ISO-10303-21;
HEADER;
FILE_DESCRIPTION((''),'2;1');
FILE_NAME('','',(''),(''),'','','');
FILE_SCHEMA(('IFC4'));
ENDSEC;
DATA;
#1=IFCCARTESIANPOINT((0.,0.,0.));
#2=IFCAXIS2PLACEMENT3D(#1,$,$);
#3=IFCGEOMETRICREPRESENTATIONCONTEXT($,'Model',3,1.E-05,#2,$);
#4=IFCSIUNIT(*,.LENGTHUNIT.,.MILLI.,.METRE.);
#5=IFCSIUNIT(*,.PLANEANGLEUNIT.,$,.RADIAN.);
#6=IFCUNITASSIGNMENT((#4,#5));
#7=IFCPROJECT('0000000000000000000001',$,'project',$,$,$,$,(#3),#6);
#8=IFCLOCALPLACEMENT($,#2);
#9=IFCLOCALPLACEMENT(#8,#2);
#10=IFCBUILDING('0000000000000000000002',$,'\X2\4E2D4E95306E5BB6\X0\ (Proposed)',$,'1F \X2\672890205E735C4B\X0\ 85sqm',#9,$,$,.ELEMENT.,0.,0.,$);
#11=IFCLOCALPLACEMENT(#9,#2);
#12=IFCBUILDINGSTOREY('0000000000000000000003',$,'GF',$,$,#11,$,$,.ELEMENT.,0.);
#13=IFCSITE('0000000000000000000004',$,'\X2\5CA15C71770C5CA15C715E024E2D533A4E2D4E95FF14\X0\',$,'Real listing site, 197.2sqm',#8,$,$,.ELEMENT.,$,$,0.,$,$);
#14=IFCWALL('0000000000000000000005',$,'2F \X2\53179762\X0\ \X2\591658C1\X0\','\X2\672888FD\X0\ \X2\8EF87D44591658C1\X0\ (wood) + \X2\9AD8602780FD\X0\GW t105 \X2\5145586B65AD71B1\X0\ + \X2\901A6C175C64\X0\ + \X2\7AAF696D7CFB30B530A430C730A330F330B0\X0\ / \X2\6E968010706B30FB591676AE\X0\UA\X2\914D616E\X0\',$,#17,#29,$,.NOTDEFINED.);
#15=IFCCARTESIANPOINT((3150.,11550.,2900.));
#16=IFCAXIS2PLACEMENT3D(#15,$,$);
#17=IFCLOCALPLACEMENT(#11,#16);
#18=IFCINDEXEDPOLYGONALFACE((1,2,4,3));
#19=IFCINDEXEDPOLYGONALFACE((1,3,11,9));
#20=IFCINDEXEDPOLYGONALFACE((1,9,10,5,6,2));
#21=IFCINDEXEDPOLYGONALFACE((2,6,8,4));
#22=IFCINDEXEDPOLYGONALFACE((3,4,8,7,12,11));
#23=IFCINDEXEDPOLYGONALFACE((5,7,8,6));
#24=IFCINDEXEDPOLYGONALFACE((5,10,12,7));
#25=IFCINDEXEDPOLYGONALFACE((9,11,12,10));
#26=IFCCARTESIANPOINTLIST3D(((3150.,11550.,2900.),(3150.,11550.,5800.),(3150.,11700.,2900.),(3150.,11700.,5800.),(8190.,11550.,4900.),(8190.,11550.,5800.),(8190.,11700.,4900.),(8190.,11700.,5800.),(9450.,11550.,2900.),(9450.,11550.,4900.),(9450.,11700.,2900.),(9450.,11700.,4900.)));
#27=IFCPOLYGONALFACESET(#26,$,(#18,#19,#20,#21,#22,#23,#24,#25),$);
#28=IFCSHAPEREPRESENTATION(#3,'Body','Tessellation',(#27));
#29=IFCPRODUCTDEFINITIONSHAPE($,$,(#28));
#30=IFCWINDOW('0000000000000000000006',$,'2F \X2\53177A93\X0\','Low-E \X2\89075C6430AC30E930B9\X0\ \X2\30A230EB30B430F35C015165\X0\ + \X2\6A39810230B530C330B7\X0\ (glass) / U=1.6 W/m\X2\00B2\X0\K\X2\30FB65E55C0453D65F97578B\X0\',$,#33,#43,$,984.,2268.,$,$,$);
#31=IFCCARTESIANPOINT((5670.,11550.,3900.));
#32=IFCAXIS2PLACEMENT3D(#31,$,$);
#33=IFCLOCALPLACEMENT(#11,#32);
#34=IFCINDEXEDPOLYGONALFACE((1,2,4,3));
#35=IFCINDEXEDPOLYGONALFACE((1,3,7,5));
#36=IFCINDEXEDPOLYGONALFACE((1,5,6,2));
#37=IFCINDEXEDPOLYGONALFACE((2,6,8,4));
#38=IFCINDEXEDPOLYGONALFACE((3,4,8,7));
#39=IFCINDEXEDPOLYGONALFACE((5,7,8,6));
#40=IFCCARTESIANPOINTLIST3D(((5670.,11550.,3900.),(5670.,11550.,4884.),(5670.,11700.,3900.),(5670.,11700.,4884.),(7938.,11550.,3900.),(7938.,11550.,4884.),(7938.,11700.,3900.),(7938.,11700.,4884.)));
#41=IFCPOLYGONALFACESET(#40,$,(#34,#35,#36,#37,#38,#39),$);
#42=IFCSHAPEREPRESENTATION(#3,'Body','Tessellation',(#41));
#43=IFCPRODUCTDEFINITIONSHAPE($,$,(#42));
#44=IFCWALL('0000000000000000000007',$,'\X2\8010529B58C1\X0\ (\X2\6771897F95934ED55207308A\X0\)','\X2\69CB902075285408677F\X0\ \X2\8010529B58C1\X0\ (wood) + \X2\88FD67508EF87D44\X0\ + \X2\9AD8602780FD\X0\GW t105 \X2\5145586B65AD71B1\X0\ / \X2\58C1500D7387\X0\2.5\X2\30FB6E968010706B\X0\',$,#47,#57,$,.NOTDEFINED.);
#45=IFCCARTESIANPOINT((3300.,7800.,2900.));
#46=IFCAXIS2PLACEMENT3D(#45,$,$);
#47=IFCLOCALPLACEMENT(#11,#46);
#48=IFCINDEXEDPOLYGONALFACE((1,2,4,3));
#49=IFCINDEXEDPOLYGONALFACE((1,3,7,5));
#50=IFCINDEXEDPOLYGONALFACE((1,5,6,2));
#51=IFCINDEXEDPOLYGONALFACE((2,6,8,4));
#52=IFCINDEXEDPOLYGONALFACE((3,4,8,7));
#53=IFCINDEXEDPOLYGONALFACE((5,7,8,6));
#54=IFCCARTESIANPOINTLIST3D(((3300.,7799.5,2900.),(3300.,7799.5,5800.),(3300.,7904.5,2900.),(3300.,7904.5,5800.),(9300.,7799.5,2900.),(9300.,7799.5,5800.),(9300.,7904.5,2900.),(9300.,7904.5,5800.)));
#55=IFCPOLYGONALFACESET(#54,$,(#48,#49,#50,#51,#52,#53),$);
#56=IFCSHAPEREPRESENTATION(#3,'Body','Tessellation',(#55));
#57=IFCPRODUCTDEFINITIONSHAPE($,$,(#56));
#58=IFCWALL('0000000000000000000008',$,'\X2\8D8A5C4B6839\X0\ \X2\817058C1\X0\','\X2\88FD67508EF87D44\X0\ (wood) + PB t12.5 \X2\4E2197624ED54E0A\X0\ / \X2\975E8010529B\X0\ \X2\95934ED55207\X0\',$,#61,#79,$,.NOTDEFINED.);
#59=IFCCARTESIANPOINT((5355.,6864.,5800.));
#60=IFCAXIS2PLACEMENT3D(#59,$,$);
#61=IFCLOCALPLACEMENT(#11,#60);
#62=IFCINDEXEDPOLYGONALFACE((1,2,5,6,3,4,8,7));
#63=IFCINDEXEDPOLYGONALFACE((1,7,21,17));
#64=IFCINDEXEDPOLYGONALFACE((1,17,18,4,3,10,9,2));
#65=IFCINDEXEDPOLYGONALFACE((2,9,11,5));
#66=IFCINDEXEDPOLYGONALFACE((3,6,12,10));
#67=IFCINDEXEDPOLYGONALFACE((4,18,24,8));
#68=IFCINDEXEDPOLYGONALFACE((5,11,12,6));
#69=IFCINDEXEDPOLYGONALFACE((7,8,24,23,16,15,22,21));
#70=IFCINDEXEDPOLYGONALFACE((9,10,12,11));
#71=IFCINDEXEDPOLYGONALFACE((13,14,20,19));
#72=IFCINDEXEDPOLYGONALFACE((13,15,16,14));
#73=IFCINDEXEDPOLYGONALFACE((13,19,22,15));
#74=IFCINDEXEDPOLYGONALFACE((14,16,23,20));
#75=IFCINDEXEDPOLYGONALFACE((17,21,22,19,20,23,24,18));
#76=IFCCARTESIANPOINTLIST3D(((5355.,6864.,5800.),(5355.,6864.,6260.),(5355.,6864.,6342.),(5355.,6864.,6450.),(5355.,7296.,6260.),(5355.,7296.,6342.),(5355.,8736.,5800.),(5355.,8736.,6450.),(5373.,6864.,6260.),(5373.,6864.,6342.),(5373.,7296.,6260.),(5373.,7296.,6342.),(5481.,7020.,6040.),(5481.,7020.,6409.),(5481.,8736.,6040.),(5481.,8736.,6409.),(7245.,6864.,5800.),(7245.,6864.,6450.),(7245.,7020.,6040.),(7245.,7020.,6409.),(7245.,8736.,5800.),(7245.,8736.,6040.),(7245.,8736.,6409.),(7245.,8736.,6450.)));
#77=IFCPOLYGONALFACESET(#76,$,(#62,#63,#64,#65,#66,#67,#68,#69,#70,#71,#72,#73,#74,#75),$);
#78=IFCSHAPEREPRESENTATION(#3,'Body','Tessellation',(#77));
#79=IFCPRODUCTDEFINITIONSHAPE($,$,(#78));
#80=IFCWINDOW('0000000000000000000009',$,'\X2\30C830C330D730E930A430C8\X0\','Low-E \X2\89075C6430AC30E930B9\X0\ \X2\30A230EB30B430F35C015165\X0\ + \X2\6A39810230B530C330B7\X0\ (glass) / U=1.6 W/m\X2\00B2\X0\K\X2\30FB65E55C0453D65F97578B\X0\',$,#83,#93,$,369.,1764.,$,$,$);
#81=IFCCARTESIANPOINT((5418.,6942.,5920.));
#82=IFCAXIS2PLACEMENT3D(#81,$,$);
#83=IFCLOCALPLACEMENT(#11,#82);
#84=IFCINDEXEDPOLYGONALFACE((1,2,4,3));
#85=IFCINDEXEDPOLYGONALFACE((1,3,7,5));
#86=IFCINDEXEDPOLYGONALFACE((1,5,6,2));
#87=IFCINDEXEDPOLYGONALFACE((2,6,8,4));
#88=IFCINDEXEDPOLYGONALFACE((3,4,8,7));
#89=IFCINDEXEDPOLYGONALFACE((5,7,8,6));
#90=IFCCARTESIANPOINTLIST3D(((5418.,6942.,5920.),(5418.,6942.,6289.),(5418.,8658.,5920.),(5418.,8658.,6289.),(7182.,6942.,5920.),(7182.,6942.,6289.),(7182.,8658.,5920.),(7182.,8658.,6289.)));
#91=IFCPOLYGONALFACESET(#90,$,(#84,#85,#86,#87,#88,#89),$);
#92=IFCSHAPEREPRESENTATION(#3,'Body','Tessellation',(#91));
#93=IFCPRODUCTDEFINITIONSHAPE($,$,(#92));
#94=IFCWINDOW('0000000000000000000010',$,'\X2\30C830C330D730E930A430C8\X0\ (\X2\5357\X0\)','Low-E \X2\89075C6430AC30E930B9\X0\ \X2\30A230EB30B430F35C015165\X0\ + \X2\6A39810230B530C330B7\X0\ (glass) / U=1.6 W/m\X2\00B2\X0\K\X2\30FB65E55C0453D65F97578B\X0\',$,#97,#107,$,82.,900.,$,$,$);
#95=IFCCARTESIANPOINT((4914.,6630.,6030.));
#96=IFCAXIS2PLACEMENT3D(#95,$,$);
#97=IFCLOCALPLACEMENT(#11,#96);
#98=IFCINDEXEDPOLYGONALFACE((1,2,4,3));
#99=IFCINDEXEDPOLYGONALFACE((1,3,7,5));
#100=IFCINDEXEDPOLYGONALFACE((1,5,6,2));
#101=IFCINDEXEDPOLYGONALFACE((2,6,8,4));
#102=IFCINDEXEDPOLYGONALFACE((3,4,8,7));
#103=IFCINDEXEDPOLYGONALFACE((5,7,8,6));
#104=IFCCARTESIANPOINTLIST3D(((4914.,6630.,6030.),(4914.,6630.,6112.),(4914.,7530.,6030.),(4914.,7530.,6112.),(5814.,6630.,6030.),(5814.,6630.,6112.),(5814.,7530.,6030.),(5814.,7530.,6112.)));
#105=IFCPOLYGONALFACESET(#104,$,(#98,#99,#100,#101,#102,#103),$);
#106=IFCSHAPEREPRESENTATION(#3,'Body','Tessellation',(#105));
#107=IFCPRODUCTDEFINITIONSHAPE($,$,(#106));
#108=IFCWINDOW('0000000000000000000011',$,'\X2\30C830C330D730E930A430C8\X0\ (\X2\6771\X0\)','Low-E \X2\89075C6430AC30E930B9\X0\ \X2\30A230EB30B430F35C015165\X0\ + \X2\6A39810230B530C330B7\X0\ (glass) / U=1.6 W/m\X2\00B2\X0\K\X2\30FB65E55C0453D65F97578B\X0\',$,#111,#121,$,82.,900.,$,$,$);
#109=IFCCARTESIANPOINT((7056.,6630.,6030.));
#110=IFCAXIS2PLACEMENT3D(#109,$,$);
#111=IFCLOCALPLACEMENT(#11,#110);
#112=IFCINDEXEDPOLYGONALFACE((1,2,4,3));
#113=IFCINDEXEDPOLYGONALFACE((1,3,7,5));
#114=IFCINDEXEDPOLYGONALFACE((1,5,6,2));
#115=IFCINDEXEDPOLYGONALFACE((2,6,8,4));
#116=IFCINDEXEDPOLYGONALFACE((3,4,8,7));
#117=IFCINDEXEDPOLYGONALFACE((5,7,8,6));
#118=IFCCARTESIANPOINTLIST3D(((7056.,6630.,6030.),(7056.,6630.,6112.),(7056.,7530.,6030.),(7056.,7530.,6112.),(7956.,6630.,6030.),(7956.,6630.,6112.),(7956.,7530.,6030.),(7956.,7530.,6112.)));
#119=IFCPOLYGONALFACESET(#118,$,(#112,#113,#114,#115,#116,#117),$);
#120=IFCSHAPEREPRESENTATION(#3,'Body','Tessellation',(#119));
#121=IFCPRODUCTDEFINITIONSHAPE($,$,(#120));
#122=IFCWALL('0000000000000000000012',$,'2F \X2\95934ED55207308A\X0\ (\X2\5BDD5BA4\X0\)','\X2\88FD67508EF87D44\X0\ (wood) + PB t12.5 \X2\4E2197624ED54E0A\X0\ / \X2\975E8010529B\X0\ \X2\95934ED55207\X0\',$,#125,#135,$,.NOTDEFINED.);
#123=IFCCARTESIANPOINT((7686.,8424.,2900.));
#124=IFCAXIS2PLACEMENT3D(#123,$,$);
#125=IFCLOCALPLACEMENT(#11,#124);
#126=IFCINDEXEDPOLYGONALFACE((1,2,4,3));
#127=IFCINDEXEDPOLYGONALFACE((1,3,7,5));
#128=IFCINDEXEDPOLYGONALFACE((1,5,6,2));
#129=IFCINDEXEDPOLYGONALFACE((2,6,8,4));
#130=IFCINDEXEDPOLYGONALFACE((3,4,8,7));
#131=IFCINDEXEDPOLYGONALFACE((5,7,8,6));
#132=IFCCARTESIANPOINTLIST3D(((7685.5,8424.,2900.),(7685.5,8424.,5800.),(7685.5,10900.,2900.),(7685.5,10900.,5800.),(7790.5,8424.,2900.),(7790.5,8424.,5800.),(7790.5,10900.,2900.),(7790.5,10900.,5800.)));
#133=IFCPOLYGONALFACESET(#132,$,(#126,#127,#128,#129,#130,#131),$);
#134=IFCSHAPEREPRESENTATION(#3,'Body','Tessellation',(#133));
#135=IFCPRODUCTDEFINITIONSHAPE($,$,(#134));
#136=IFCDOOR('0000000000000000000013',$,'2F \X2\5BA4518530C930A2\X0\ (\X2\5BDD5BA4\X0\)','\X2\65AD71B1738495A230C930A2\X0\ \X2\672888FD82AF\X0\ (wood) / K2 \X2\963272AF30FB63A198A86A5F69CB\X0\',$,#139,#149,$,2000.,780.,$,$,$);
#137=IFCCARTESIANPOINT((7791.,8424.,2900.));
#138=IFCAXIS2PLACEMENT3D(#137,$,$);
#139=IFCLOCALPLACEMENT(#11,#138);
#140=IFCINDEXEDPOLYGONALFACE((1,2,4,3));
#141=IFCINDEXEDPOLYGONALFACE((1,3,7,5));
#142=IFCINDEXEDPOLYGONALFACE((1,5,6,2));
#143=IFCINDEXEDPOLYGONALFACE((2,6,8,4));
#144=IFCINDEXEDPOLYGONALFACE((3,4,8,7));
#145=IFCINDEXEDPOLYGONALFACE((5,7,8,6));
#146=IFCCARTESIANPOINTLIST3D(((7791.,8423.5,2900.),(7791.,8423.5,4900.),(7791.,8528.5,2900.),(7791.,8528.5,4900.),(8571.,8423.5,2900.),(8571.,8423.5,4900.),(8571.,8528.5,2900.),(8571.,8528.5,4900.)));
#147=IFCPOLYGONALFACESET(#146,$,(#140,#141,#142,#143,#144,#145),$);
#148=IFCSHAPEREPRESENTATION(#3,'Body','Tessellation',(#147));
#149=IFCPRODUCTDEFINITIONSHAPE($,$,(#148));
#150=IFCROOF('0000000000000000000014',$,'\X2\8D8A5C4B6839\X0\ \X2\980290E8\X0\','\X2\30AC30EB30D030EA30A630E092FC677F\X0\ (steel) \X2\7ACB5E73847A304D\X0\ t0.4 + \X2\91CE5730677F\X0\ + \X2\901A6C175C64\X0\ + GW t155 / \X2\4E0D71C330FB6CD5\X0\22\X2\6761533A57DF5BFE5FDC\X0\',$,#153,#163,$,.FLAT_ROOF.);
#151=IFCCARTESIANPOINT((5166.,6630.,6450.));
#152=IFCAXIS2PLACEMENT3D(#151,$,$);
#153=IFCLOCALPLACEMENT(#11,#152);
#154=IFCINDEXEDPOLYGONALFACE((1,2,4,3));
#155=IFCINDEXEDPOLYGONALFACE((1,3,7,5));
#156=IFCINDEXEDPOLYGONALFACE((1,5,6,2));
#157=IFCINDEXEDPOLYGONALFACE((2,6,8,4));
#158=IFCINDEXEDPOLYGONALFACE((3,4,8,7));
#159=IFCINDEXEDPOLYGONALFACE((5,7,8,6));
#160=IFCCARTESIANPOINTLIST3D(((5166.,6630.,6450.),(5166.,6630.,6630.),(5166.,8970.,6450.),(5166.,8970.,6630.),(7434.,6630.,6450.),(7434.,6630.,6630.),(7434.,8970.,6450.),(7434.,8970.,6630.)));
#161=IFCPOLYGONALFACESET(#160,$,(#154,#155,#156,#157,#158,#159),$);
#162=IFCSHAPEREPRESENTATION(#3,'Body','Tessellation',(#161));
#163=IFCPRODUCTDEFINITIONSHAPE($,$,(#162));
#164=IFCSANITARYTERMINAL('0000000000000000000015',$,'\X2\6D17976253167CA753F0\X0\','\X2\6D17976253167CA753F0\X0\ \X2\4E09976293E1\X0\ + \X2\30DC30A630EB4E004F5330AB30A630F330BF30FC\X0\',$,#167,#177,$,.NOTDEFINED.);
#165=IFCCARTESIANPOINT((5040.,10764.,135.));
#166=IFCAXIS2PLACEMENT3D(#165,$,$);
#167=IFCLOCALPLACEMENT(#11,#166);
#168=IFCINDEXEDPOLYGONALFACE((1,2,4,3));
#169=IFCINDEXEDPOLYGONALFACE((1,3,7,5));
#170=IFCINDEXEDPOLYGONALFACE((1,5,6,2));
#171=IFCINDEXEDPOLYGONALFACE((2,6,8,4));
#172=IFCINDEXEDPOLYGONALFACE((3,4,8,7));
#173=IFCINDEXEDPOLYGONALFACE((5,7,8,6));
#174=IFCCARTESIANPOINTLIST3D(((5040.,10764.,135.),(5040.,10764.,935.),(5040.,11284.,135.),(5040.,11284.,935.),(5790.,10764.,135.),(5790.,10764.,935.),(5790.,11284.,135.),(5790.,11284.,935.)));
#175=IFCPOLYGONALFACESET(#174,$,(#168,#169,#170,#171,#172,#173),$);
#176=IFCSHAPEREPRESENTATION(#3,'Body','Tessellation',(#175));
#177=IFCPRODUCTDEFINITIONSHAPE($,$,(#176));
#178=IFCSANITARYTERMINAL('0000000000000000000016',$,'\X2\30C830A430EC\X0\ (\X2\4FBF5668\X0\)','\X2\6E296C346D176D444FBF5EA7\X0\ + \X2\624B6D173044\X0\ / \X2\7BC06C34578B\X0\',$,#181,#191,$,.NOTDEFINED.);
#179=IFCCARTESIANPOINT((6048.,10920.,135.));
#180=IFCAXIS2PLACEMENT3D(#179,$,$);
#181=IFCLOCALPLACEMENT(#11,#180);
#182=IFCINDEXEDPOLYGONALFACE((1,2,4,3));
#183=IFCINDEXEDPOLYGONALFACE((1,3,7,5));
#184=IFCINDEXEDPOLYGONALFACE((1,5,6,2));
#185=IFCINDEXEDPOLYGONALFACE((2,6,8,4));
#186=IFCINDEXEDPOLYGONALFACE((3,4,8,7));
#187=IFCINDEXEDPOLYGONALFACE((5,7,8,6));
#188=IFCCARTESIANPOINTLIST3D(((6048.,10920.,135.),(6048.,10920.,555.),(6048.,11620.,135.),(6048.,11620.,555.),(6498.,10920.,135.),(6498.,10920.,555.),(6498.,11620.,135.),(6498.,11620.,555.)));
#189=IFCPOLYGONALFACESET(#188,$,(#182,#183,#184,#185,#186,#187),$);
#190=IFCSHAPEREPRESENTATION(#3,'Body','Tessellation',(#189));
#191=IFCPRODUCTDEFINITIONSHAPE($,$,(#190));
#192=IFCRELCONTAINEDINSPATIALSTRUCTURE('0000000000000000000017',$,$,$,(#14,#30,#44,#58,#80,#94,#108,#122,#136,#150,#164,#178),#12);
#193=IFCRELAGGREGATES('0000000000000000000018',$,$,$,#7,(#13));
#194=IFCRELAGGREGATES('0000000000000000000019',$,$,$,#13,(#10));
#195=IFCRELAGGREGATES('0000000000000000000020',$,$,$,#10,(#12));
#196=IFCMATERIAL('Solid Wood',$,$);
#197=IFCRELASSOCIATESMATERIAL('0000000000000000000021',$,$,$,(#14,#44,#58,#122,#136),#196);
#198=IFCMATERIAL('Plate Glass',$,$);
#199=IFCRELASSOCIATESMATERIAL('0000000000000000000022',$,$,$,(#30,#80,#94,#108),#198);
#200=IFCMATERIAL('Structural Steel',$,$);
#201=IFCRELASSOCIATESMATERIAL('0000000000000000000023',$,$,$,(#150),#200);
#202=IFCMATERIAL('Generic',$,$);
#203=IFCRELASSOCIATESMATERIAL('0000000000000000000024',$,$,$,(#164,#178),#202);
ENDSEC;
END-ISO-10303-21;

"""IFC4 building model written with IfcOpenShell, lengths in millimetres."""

from ifc_helpers import new_model, si_unit, frame, frame_2d, origin, place, context, project, spatial, rectangle, extrude, material, element, fill, save


model = new_model("IFC4")

# Units and contexts
model_context = context("Model", 3, precision=1e-05, world=origin())
ifc_project = project(units=[si_unit("LENGTHUNIT", "METRE", prefix="MILLI"), si_unit("PLANEANGLEUNIT", "RADIAN")], contexts=[model_context])

# Site, building, storey
site_placement = place(None, origin())
site = spatial("IfcSite", under=ifc_project, at=site_placement, Name="岡山県岡山市中区中井４", ObjectType="Real listing site, 197.2sqm", CompositionType="ELEMENT", RefElevation=0.0)
building_placement = place(site_placement, origin())
building = spatial("IfcBuilding", under=site, at=building_placement, Name="中井の家 (Proposed)", ObjectType="1F 木造平屋 85sqm", CompositionType="ELEMENT", ElevationOfRefHeight=0.0, ElevationOfTerrain=0.0)
storey_placement = place(building_placement, origin())
storey = spatial("IfcBuildingStorey", under=building, at=storey_placement, Name="GF", CompositionType="ELEMENT", Elevation=0.0)

# Wall, opening, window
ifc_material_1 = material(Name="Solid Wood")
wall_1_placement = place(storey_placement, frame((3150.0, 11550.0, 2900.0)))
wall_1 = element("IfcWall", 1, at=wall_1_placement, inside=storey, material=ifc_material_1, Name="2F 北面 外壁", Description="木製 軸組外壁 (wood) + 高性能GW t105 充填断熱 + 通気層 + 窯業系サイディング / 準耐火・外皮UA配慮", PredefinedType="NOTDEFINED", context=model_context, shape_type="SweptSolid", body=[
    extrude(rectangle(XDim=6300.0, YDim=150.0, at=frame_2d((3150.0, 75.0))), frame((3150.0, 11550.0, 2900.0)), (0.0, 0.0, 1.0), 2900.0),
])
opening_1_placement = place(storey_placement, frame((5670.0, 11550.0, 3900.0)))
opening_1 = element("IfcOpeningElement", 2, at=opening_1_placement, cuts=wall_1, PredefinedType="NOTDEFINED", context=model_context, shape_type="SweptSolid", body=[
    extrude(rectangle(XDim=2268.0, YDim=150.0, at=frame_2d((1134.0, 75.0))), frame((5670.0, 11550.0, 3900.0)), (0.0, 0.0, 1.0), 984.0),
])
ifc_material_2 = material(Name="Plate Glass")
window_1_placement = place(storey_placement, frame((5670.0, 11550.0, 3900.0)))
window_1 = element("IfcWindow", 3, at=window_1_placement, inside=storey, material=ifc_material_2, Name="2F 北窓", Description="Low-E 複層ガラス アルゴン封入 + 樹脂サッシ (glass) / U=1.6 W/m²K・日射取得型", OverallHeight=984.0, OverallWidth=2268.0, context=model_context, shape_type="SweptSolid", body=[
    extrude(rectangle(XDim=2268.0, YDim=150.0, at=frame_2d((1134.0, 75.0))), frame((5670.0, 11550.0, 3900.0)), (0.0, 0.0, 1.0), 984.0),
])
fill(opening_1, window_1)

# Wall
wall_2_placement = place(storey_placement, frame((3300.0, 7800.0, 2900.0)))
element("IfcWall", 4, at=wall_2_placement, inside=storey, material=ifc_material_1, Name="耐力壁 (東西間仕切り)", Description="構造用合板 耐力壁 (wood) + 製材軸組 + 高性能GW t105 充填断熱 / 壁倍率2.5・準耐火", PredefinedType="NOTDEFINED", context=model_context, shape_type="SweptSolid", body=[
    extrude(rectangle(XDim=6000.0, YDim=105.0, at=frame_2d((3000.0, 52.0))), frame((3300.0, 7800.0, 2900.0)), (0.0, 0.0, 1.0), 2900.0),
])

# Wall, openings, windows
wall_3_placement = place(storey_placement, frame((5355.0, 6864.0, 5800.0)))
wall_3 = element("IfcWall", 5, at=wall_3_placement, inside=storey, material=ifc_material_1, Name="越屋根 腰壁", Description="製材軸組 (wood) + PB t12.5 両面仕上 / 非耐力 間仕切", PredefinedType="NOTDEFINED", context=model_context, shape_type="SweptSolid", body=[
    extrude(rectangle(XDim=1890.0, YDim=1872.0, at=frame_2d((945.0, 936.0))), frame((5355.0, 6864.0, 5800.0)), (0.0, 0.0, 1.0), 650.0),
])
opening_2_placement = place(storey_placement, frame((5418.0, 6942.0, 5920.0)))
opening_2 = element("IfcOpeningElement", 6, at=opening_2_placement, cuts=wall_3, PredefinedType="NOTDEFINED", context=model_context, shape_type="SweptSolid", body=[
    extrude(rectangle(XDim=1764.0, YDim=1716.0, at=frame_2d((882.0, 858.0))), frame((5418.0, 6942.0, 5920.0)), (0.0, 0.0, 1.0), 369.0),
])
opening_3_placement = place(storey_placement, frame((4914.0, 6630.0, 6030.0)))
opening_3 = element("IfcOpeningElement", 7, at=opening_3_placement, cuts=wall_3, PredefinedType="NOTDEFINED", context=model_context, shape_type="SweptSolid", body=[
    extrude(rectangle(XDim=900.0, YDim=900.0, at=frame_2d((450.0, 450.0))), frame((4914.0, 6630.0, 6030.0)), (0.0, 0.0, 1.0), 82.0),
])
opening_4_placement = place(storey_placement, frame((7056.0, 6630.0, 6030.0)))
opening_4 = element("IfcOpeningElement", 8, at=opening_4_placement, cuts=wall_3, PredefinedType="NOTDEFINED", context=model_context, shape_type="SweptSolid", body=[
    extrude(rectangle(XDim=900.0, YDim=900.0, at=frame_2d((450.0, 450.0))), frame((7056.0, 6630.0, 6030.0)), (0.0, 0.0, 1.0), 82.0),
])
window_2_placement = place(storey_placement, frame((5418.0, 6942.0, 5920.0)))
window_2 = element("IfcWindow", 9, at=window_2_placement, inside=storey, material=ifc_material_2, Name="トップライト", Description="Low-E 複層ガラス アルゴン封入 + 樹脂サッシ (glass) / U=1.6 W/m²K・日射取得型", OverallHeight=369.0, OverallWidth=1764.0, context=model_context, shape_type="SweptSolid", body=[
    extrude(rectangle(XDim=1764.0, YDim=1716.0, at=frame_2d((882.0, 858.0))), frame((5418.0, 6942.0, 5920.0)), (0.0, 0.0, 1.0), 369.0),
])
fill(opening_2, window_2)
window_3_placement = place(storey_placement, frame((4914.0, 6630.0, 6030.0)))
window_3 = element("IfcWindow", 10, at=window_3_placement, inside=storey, material=ifc_material_2, Name="トップライト (南)", Description="Low-E 複層ガラス アルゴン封入 + 樹脂サッシ (glass) / U=1.6 W/m²K・日射取得型", OverallHeight=82.0, OverallWidth=900.0, context=model_context, shape_type="SweptSolid", body=[
    extrude(rectangle(XDim=900.0, YDim=900.0, at=frame_2d((450.0, 450.0))), frame((4914.0, 6630.0, 6030.0)), (0.0, 0.0, 1.0), 82.0),
])
fill(opening_3, window_3)
window_4_placement = place(storey_placement, frame((7056.0, 6630.0, 6030.0)))
window_4 = element("IfcWindow", 11, at=window_4_placement, inside=storey, material=ifc_material_2, Name="トップライト (東)", Description="Low-E 複層ガラス アルゴン封入 + 樹脂サッシ (glass) / U=1.6 W/m²K・日射取得型", OverallHeight=82.0, OverallWidth=900.0, context=model_context, shape_type="SweptSolid", body=[
    extrude(rectangle(XDim=900.0, YDim=900.0, at=frame_2d((450.0, 450.0))), frame((7056.0, 6630.0, 6030.0)), (0.0, 0.0, 1.0), 82.0),
])
fill(opening_4, window_4)

# Wall
wall_4_placement = place(storey_placement, frame((7686.0, 8424.0, 2900.0)))
element("IfcWall", 12, at=wall_4_placement, inside=storey, material=ifc_material_1, Name="2F 間仕切り (寝室)", Description="製材軸組 (wood) + PB t12.5 両面仕上 / 非耐力 間仕切", PredefinedType="NOTDEFINED", context=model_context, shape_type="SweptSolid", body=[
    extrude(rectangle(XDim=105.0, YDim=2476.0, at=frame_2d((52.0, 1238.0))), frame((7686.0, 8424.0, 2900.0)), (0.0, 0.0, 1.0), 2900.0),
])

# Door
door_placement = place(storey_placement, frame((7791.0, 8424.0, 2900.0)))
element("IfcDoor", 13, at=door_placement, inside=storey, material=ifc_material_1, Name="2F 室内ドア (寝室)", Description="断熱玄関ドア 木製芯 (wood) / K2 防犯・採風機構", OverallHeight=2000.0, OverallWidth=780.0, context=model_context, shape_type="SweptSolid", body=[
    extrude(rectangle(XDim=780.0, YDim=105.0, at=frame_2d((390.0, 52.0))), frame((7791.0, 8424.0, 2900.0)), (0.0, 0.0, 1.0), 2000.0),
])

# Roof
ifc_material_3 = material(Name="Structural Steel")
roof_placement = place(storey_placement, frame((5166.0, 6630.0, 6450.0)))
element("IfcRoof", 14, at=roof_placement, inside=storey, material=ifc_material_3, Name="越屋根 頂部", Description="ガルバリウム鋼板 (steel) 立平葺き t0.4 + 野地板 + 通気層 + GW t155 / 不燃・法22条区域対応", PredefinedType="FLAT_ROOF", context=model_context, shape_type="SweptSolid", body=[
    extrude(rectangle(XDim=2268.0, YDim=2340.0, at=frame_2d((1134.0, 1170.0))), frame((5166.0, 6630.0, 6450.0)), (0.0, 0.0, 1.0), 180.0),
])

# Sanitary terminals
ifc_material_4 = material(Name="Generic")
sanitary_terminal_1_placement = place(storey_placement, frame((5040.0, 10764.0, 135.0)))
element("IfcSanitaryTerminal", 15, at=sanitary_terminal_1_placement, inside=storey, material=ifc_material_4, Name="洗面化粧台", Description="洗面化粧台 三面鏡 + ボウル一体カウンター", PredefinedType="NOTDEFINED", context=model_context, shape_type="SweptSolid", body=[
    extrude(rectangle(XDim=750.0, YDim=520.0, at=frame_2d((375.0, 260.0))), frame((5040.0, 10764.0, 135.0)), (0.0, 0.0, 1.0), 800.0),
])
sanitary_terminal_2_placement = place(storey_placement, frame((6048.0, 10920.0, 135.0)))
element("IfcSanitaryTerminal", 16, at=sanitary_terminal_2_placement, inside=storey, material=ifc_material_4, Name="トイレ (便器)", Description="温水洗浄便座 + 手洗い / 節水型", PredefinedType="NOTDEFINED", context=model_context, shape_type="SweptSolid", body=[
    extrude(rectangle(XDim=450.0, YDim=700.0, at=frame_2d((225.0, 350.0))), frame((6048.0, 10920.0, 135.0)), (0.0, 0.0, 1.0), 420.0),
])

save(model, "model.ifc")
